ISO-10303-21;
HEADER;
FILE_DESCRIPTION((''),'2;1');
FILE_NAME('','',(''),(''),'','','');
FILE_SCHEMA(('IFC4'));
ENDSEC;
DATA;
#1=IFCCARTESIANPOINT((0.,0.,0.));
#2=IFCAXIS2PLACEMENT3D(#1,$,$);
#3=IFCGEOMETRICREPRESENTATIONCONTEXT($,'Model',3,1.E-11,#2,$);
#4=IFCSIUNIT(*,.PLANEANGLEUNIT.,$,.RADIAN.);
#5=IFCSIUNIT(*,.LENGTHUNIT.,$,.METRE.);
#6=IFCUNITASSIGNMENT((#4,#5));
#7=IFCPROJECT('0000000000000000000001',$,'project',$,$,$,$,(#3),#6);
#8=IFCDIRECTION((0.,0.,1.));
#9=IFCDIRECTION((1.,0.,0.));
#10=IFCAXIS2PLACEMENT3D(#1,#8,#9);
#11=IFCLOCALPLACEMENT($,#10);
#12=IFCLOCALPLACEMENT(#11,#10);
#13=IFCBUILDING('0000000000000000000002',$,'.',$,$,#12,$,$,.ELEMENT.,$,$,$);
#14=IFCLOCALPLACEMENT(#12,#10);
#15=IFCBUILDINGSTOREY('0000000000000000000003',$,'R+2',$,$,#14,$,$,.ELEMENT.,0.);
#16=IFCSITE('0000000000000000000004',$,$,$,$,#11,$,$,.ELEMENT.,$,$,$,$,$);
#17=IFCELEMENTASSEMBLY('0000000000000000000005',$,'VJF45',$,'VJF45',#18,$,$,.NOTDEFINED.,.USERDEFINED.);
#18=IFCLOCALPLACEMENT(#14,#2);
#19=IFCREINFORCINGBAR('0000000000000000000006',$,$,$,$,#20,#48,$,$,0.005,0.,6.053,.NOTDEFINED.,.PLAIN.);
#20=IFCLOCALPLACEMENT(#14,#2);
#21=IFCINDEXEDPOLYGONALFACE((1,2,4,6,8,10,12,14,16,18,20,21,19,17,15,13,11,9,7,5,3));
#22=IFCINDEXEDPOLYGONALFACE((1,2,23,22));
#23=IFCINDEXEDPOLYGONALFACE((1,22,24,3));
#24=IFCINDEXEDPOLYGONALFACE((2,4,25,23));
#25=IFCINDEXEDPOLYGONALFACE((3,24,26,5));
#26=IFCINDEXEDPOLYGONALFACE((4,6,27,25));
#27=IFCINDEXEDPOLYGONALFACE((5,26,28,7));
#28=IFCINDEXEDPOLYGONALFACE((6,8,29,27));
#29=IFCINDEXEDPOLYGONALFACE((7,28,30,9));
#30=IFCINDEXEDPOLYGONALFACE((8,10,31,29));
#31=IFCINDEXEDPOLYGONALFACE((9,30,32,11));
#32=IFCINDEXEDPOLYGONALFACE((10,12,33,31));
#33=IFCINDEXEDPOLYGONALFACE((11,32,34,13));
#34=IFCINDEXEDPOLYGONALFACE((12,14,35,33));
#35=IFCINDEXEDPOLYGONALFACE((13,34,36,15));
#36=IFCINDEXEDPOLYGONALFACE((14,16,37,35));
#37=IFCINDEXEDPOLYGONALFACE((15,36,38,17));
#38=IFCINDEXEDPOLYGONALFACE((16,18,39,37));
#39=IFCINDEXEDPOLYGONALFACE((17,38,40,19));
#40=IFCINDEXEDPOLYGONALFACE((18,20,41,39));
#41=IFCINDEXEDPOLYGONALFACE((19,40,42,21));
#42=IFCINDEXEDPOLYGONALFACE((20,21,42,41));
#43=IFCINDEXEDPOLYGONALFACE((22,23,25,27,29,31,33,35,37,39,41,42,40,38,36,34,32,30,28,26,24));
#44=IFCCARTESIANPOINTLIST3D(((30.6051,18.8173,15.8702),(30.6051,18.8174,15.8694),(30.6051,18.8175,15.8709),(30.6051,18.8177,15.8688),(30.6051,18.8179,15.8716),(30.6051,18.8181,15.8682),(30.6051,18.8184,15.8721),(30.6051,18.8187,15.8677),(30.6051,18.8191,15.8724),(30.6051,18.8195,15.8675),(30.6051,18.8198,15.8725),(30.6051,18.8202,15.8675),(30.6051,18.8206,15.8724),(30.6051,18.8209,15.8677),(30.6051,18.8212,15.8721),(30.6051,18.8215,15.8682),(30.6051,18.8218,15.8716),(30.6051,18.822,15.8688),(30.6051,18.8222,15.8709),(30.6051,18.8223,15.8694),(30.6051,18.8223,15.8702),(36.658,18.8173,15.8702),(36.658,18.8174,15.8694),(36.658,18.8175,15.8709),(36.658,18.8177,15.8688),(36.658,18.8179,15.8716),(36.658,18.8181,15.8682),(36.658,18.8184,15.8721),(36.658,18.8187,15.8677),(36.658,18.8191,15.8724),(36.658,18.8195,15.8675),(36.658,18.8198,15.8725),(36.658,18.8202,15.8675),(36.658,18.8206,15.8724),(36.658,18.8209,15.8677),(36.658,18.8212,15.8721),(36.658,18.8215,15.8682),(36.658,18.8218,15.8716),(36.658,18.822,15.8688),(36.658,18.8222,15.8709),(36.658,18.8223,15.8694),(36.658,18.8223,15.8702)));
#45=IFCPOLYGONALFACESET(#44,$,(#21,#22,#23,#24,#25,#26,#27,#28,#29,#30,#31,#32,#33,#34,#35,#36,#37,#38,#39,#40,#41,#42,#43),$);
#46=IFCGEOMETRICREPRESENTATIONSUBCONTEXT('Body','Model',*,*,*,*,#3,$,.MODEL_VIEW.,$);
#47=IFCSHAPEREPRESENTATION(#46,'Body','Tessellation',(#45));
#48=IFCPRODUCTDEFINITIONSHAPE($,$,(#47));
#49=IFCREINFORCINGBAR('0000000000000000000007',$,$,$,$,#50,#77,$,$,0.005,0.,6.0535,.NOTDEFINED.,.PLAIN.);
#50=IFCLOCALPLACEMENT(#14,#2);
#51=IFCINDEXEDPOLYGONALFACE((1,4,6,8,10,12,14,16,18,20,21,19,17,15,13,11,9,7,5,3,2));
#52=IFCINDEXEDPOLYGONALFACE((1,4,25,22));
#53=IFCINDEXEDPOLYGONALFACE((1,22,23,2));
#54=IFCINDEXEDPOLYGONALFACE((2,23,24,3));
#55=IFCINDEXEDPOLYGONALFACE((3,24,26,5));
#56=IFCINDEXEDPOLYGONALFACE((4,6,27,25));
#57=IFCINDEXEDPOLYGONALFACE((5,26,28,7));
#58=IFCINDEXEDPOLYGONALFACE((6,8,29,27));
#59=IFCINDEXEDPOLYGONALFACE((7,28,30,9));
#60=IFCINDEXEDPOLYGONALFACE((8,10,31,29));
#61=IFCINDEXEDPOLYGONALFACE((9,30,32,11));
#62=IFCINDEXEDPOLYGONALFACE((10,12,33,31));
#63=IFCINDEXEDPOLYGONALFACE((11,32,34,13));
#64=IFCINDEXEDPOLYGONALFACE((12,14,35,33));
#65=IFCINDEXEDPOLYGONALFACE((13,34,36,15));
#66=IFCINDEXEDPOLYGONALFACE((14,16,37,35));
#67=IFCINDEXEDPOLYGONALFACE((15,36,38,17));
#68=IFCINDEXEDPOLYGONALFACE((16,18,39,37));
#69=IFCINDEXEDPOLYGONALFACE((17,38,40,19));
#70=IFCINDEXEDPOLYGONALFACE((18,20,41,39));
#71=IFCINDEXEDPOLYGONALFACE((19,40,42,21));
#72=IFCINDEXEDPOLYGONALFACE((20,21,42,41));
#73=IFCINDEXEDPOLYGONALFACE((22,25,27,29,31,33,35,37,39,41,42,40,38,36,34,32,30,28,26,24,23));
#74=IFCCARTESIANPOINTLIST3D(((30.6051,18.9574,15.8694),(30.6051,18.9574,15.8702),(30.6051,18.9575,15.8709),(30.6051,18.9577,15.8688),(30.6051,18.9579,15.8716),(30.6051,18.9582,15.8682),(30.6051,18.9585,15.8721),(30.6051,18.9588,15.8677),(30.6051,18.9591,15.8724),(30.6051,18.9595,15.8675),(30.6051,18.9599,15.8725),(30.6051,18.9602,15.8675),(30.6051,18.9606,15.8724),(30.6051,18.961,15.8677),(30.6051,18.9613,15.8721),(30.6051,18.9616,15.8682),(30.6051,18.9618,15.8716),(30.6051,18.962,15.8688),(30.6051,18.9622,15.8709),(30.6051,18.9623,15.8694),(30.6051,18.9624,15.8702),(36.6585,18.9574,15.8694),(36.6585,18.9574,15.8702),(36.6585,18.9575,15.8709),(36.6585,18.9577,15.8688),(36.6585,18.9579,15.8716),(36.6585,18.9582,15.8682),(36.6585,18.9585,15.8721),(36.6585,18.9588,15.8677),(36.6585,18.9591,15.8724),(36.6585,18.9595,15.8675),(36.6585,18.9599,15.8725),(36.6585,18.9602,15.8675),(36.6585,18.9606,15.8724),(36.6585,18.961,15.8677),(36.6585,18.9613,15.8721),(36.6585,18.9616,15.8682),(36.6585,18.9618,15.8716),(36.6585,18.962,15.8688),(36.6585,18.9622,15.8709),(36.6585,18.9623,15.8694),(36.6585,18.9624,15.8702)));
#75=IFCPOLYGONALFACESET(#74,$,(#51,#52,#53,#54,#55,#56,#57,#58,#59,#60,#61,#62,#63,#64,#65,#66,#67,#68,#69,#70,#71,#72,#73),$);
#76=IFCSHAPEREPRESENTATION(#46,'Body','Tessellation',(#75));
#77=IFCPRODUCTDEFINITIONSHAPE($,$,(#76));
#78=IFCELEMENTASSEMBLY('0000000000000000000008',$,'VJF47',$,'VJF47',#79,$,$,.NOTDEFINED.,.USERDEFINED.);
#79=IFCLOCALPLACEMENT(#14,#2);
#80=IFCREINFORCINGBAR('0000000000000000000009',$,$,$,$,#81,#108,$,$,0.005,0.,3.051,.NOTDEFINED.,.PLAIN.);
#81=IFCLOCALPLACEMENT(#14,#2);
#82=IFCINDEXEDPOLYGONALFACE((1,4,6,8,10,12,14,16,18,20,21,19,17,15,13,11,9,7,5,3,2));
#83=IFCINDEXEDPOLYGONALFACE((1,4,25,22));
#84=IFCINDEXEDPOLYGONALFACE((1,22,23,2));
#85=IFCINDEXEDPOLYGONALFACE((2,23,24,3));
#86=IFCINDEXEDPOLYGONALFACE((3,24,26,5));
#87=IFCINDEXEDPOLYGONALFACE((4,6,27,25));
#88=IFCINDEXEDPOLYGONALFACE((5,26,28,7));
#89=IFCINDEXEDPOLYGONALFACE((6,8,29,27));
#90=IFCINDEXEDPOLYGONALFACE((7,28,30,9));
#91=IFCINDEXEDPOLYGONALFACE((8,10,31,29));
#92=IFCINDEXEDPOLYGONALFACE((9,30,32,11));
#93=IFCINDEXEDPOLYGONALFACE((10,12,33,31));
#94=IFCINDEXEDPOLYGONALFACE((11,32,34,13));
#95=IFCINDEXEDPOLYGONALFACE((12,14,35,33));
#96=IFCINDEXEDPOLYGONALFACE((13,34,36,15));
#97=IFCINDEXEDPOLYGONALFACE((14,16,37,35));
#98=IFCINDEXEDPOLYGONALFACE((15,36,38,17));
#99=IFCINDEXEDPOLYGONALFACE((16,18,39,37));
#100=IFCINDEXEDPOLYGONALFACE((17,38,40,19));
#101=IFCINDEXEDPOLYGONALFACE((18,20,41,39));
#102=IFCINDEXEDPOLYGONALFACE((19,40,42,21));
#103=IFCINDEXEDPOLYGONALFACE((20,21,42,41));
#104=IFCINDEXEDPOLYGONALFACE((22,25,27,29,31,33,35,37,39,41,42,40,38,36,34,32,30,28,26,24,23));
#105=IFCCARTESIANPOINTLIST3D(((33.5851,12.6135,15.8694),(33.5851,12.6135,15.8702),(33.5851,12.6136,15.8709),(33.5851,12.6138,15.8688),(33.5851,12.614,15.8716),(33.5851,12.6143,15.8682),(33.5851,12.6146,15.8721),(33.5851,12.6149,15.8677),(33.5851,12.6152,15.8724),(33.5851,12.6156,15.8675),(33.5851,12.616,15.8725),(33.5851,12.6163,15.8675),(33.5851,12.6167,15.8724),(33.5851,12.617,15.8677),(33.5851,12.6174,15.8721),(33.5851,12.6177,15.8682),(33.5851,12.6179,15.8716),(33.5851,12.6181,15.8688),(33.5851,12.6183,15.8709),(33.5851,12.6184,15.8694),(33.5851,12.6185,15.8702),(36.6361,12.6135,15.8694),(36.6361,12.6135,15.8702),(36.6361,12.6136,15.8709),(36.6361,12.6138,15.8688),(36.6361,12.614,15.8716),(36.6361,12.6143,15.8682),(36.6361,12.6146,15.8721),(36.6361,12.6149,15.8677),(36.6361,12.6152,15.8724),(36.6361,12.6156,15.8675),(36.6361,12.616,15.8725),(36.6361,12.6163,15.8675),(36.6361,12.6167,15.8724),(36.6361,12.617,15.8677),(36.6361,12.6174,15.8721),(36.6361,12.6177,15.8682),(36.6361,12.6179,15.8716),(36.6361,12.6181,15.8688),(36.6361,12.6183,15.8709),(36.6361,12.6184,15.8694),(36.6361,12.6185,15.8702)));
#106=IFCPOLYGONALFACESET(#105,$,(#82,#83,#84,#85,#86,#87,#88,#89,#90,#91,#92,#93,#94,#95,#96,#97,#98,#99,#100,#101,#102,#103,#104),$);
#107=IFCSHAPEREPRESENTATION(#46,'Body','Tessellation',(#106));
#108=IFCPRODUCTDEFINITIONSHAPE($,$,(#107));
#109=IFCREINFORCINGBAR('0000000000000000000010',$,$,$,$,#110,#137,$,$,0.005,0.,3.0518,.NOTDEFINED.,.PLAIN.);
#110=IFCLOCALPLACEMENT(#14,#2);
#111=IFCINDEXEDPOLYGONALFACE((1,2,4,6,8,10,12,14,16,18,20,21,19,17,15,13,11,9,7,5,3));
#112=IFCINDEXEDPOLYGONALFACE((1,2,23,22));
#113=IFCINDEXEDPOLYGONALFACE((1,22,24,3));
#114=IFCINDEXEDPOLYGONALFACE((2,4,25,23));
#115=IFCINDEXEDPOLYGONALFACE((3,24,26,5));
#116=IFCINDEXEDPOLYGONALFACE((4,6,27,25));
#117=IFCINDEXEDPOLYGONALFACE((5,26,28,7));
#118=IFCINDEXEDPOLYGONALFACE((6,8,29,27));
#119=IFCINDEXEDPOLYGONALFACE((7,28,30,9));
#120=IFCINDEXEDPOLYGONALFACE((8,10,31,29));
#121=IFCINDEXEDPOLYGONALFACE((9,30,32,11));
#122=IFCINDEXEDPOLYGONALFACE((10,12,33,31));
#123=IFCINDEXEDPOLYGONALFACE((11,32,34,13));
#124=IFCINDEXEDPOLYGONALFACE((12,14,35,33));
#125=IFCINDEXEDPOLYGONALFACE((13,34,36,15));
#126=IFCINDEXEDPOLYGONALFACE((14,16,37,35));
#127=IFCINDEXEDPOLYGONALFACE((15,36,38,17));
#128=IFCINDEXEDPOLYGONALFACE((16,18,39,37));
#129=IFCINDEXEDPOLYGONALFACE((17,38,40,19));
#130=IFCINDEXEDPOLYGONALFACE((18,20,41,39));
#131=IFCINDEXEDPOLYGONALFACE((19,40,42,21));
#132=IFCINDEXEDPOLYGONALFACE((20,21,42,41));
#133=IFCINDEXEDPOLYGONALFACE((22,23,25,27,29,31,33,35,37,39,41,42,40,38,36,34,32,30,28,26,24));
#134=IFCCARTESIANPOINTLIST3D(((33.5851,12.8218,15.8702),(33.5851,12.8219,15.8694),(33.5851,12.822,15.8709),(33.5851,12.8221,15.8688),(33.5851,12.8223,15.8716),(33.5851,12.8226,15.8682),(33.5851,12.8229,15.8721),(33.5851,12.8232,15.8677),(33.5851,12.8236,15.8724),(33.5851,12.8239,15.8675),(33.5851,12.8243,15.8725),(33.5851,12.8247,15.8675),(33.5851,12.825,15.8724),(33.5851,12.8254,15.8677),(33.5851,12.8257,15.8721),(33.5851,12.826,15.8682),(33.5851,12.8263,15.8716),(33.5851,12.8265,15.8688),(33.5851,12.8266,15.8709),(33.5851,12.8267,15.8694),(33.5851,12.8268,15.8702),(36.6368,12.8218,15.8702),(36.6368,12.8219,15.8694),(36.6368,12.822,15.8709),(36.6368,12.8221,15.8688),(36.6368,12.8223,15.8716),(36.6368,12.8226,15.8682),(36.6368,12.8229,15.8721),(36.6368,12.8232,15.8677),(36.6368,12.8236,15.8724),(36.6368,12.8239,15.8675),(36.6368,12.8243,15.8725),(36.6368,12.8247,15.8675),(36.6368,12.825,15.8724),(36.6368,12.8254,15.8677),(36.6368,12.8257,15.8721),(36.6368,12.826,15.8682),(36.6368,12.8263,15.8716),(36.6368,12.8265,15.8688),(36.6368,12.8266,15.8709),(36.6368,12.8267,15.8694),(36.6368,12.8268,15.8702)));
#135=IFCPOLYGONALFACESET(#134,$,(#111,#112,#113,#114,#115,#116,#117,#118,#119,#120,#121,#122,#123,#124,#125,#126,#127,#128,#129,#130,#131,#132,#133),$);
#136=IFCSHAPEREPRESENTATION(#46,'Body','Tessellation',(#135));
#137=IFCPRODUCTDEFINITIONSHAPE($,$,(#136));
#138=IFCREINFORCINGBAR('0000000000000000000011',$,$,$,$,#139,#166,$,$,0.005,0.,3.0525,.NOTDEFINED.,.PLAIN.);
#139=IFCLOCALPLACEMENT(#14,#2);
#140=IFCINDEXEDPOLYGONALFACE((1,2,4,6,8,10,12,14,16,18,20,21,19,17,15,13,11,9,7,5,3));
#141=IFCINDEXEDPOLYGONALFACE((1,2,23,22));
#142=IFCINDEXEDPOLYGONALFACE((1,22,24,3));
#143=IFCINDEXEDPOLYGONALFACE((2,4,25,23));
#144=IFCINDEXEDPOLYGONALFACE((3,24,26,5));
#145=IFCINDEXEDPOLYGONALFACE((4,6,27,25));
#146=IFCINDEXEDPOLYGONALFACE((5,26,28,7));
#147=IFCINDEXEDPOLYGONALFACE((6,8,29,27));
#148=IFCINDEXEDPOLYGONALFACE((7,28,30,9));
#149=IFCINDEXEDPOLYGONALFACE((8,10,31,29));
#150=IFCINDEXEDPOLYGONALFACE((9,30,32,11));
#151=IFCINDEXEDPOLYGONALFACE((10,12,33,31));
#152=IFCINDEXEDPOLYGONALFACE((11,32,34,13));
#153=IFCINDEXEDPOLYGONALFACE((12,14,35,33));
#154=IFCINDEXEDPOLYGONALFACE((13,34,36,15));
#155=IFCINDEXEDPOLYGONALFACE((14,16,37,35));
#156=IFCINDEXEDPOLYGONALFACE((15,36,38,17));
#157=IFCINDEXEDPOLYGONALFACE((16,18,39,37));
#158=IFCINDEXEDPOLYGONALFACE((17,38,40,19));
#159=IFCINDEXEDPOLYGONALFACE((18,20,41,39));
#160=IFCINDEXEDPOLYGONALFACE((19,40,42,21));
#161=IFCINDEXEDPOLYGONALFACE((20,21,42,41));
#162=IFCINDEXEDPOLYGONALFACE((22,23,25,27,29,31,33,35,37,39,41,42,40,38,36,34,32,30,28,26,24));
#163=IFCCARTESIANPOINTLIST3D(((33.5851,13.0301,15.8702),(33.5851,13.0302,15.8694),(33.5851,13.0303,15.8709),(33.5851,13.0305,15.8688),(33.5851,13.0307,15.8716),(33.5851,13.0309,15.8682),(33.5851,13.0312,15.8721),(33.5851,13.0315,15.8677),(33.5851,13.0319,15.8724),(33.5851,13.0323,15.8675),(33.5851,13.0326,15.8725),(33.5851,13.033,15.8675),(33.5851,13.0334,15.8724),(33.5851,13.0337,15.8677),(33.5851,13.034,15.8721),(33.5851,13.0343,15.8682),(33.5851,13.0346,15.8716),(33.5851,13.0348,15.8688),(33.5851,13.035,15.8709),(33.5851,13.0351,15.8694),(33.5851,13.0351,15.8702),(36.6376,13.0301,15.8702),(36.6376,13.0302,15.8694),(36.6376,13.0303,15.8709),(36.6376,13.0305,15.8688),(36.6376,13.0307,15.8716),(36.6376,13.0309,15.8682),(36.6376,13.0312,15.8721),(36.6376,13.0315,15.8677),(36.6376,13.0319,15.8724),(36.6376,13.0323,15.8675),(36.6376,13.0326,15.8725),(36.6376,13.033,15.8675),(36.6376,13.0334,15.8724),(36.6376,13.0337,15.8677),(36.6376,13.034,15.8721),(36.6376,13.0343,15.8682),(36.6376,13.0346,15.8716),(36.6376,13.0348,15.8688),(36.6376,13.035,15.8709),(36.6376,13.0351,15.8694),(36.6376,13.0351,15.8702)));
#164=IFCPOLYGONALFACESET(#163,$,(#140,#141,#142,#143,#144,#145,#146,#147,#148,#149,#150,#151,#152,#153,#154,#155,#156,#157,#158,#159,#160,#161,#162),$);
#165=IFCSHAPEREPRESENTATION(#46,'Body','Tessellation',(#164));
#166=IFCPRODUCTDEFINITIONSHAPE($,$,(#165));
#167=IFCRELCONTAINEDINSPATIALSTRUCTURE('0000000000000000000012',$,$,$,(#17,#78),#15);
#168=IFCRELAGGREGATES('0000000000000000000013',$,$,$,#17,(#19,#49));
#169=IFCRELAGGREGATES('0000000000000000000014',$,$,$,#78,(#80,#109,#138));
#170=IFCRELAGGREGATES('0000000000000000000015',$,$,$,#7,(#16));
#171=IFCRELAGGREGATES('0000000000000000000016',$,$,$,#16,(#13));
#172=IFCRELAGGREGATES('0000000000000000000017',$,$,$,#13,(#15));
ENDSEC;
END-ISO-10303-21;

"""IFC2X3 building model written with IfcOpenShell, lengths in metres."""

from ifc_helpers import new_model, entity, si_unit, origin, origin_with_axes, place, context, subcontext, project, spatial, shape, element, aggregate, save


model = new_model("IFC2X3")

# Units and contexts
model_context = context("Model", 3, precision=1e-11, world=origin())
body_context = subcontext(model_context, "Body", "Model", "MODEL_VIEW")
ifc_project = project(units=[si_unit("PLANEANGLEUNIT", "RADIAN"), si_unit("LENGTHUNIT", "METRE")], contexts=[model_context])

# Site, building, storey
site_placement = place(None, origin_with_axes())
site = spatial("IfcSite", under=ifc_project, at=site_placement, CompositionType="ELEMENT")
building_placement = place(site_placement, origin_with_axes())
building = spatial("IfcBuilding", under=site, at=building_placement, Name=".", CompositionType="ELEMENT")
storey_placement = place(building_placement, origin_with_axes())
storey = spatial("IfcBuildingStorey", under=building, at=storey_placement, Name="R+2", CompositionType="ELEMENT", Elevation=0.0)

# Element assemblies, reinforcing bars
assembly_1_placement = place(storey_placement, origin_with_axes())
assembly_1 = element("IfcElementAssembly", 1, at=assembly_1_placement, inside=storey, Name="VJF45", ObjectType="VJF45", AssemblyPlace="NOTDEFINED", PredefinedType="USERDEFINED")
reinforcing_bar_1_placement = place(assembly_1_placement, origin_with_axes())
reinforcing_bar_1 = element("IfcReinforcingBar", 2, at=reinforcing_bar_1_placement, BarLength=6.053, BarRole="NOTDEFINED", BarSurface="PLAIN", CrossSectionArea=0.0, NominalDiameter=0.005, shapes=[
    shape(body_context, "Body", "AdvancedSweptSolid", [entity("IfcSweptDiskSolid", entity("IfcPolyline", [entity("IfcCartesianPoint", [30.6051, 18.8198, 15.87]), entity("IfcCartesianPoint", [36.658, 18.8198, 15.87])]), 0.0025, None, 0.0, 6.053)]),
    shape(body_context, "Body", "AdvancedSweptSolid", [entity("IfcSweptDiskSolid", entity("IfcPolyline", [entity("IfcCartesianPoint", [30.6051, 18.8198, 15.87]), entity("IfcCartesianPoint", [36.658, 18.8198, 15.87])]), 0.0025, None, 0.0, 6.053)]),
])
reinforcing_bar_2_placement = place(assembly_1_placement, origin_with_axes())
reinforcing_bar_2 = element("IfcReinforcingBar", 3, at=reinforcing_bar_2_placement, BarLength=6.0535, BarRole="NOTDEFINED", BarSurface="PLAIN", CrossSectionArea=0.0, NominalDiameter=0.005, shapes=[
    shape(body_context, "Body", "AdvancedSweptSolid", [entity("IfcSweptDiskSolid", entity("IfcPolyline", [entity("IfcCartesianPoint", [30.6051, 18.9599, 15.87]), entity("IfcCartesianPoint", [36.6585, 18.9599, 15.87])]), 0.0025, None, 0.0, 6.0535)]),
    shape(body_context, "Body", "AdvancedSweptSolid", [entity("IfcSweptDiskSolid", entity("IfcPolyline", [entity("IfcCartesianPoint", [30.6051, 18.9599, 15.87]), entity("IfcCartesianPoint", [36.6585, 18.9599, 15.87])]), 0.0025, None, 0.0, 6.0535)]),
])
aggregate(assembly_1, [reinforcing_bar_1, reinforcing_bar_2])
assembly_2_placement = place(storey_placement, origin_with_axes())
assembly_2 = element("IfcElementAssembly", 4, at=assembly_2_placement, inside=storey, Name="VJF47", ObjectType="VJF47", AssemblyPlace="NOTDEFINED", PredefinedType="USERDEFINED")
reinforcing_bar_3_placement = place(assembly_2_placement, origin_with_axes())
reinforcing_bar_3 = element("IfcReinforcingBar", 5, at=reinforcing_bar_3_placement, BarLength=3.051, BarRole="NOTDEFINED", BarSurface="PLAIN", CrossSectionArea=0.0, NominalDiameter=0.005, shapes=[
    shape(body_context, "Body", "AdvancedSweptSolid", [entity("IfcSweptDiskSolid", entity("IfcPolyline", [entity("IfcCartesianPoint", [33.5851, 12.616, 15.87]), entity("IfcCartesianPoint", [36.6361, 12.616, 15.87])]), 0.0025, None, 0.0, 3.051)]),
    shape(body_context, "Body", "AdvancedSweptSolid", [entity("IfcSweptDiskSolid", entity("IfcPolyline", [entity("IfcCartesianPoint", [33.5851, 12.616, 15.87]), entity("IfcCartesianPoint", [36.6361, 12.616, 15.87])]), 0.0025, None, 0.0, 3.051)]),
])
reinforcing_bar_4_placement = place(assembly_2_placement, origin_with_axes())
reinforcing_bar_4 = element("IfcReinforcingBar", 6, at=reinforcing_bar_4_placement, BarLength=3.0518, BarRole="NOTDEFINED", BarSurface="PLAIN", CrossSectionArea=0.0, NominalDiameter=0.005, shapes=[
    shape(body_context, "Body", "AdvancedSweptSolid", [entity("IfcSweptDiskSolid", entity("IfcPolyline", [entity("IfcCartesianPoint", [33.5851, 12.8243, 15.87]), entity("IfcCartesianPoint", [36.6368, 12.8243, 15.87])]), 0.0025, None, 0.0, 3.0518)]),
    shape(body_context, "Body", "AdvancedSweptSolid", [entity("IfcSweptDiskSolid", entity("IfcPolyline", [entity("IfcCartesianPoint", [33.5851, 12.8243, 15.87]), entity("IfcCartesianPoint", [36.6368, 12.8243, 15.87])]), 0.0025, None, 0.0, 3.0518)]),
])
reinforcing_bar_5_placement = place(assembly_2_placement, origin_with_axes())
reinforcing_bar_5 = element("IfcReinforcingBar", 7, at=reinforcing_bar_5_placement, BarLength=3.0525, BarRole="NOTDEFINED", BarSurface="PLAIN", CrossSectionArea=0.0, NominalDiameter=0.005, shapes=[
    shape(body_context, "Body", "AdvancedSweptSolid", [entity("IfcSweptDiskSolid", entity("IfcPolyline", [entity("IfcCartesianPoint", [33.5851, 13.0326, 15.87]), entity("IfcCartesianPoint", [36.6376, 13.0326, 15.87])]), 0.0025, None, 0.0, 3.0525)]),
    shape(body_context, "Body", "AdvancedSweptSolid", [entity("IfcSweptDiskSolid", entity("IfcPolyline", [entity("IfcCartesianPoint", [33.5851, 13.0326, 15.87]), entity("IfcCartesianPoint", [36.6376, 13.0326, 15.87])]), 0.0025, None, 0.0, 3.0525)]),
])
aggregate(assembly_2, [reinforcing_bar_3, reinforcing_bar_4, reinforcing_bar_5])

save(model, "model.ifc")
